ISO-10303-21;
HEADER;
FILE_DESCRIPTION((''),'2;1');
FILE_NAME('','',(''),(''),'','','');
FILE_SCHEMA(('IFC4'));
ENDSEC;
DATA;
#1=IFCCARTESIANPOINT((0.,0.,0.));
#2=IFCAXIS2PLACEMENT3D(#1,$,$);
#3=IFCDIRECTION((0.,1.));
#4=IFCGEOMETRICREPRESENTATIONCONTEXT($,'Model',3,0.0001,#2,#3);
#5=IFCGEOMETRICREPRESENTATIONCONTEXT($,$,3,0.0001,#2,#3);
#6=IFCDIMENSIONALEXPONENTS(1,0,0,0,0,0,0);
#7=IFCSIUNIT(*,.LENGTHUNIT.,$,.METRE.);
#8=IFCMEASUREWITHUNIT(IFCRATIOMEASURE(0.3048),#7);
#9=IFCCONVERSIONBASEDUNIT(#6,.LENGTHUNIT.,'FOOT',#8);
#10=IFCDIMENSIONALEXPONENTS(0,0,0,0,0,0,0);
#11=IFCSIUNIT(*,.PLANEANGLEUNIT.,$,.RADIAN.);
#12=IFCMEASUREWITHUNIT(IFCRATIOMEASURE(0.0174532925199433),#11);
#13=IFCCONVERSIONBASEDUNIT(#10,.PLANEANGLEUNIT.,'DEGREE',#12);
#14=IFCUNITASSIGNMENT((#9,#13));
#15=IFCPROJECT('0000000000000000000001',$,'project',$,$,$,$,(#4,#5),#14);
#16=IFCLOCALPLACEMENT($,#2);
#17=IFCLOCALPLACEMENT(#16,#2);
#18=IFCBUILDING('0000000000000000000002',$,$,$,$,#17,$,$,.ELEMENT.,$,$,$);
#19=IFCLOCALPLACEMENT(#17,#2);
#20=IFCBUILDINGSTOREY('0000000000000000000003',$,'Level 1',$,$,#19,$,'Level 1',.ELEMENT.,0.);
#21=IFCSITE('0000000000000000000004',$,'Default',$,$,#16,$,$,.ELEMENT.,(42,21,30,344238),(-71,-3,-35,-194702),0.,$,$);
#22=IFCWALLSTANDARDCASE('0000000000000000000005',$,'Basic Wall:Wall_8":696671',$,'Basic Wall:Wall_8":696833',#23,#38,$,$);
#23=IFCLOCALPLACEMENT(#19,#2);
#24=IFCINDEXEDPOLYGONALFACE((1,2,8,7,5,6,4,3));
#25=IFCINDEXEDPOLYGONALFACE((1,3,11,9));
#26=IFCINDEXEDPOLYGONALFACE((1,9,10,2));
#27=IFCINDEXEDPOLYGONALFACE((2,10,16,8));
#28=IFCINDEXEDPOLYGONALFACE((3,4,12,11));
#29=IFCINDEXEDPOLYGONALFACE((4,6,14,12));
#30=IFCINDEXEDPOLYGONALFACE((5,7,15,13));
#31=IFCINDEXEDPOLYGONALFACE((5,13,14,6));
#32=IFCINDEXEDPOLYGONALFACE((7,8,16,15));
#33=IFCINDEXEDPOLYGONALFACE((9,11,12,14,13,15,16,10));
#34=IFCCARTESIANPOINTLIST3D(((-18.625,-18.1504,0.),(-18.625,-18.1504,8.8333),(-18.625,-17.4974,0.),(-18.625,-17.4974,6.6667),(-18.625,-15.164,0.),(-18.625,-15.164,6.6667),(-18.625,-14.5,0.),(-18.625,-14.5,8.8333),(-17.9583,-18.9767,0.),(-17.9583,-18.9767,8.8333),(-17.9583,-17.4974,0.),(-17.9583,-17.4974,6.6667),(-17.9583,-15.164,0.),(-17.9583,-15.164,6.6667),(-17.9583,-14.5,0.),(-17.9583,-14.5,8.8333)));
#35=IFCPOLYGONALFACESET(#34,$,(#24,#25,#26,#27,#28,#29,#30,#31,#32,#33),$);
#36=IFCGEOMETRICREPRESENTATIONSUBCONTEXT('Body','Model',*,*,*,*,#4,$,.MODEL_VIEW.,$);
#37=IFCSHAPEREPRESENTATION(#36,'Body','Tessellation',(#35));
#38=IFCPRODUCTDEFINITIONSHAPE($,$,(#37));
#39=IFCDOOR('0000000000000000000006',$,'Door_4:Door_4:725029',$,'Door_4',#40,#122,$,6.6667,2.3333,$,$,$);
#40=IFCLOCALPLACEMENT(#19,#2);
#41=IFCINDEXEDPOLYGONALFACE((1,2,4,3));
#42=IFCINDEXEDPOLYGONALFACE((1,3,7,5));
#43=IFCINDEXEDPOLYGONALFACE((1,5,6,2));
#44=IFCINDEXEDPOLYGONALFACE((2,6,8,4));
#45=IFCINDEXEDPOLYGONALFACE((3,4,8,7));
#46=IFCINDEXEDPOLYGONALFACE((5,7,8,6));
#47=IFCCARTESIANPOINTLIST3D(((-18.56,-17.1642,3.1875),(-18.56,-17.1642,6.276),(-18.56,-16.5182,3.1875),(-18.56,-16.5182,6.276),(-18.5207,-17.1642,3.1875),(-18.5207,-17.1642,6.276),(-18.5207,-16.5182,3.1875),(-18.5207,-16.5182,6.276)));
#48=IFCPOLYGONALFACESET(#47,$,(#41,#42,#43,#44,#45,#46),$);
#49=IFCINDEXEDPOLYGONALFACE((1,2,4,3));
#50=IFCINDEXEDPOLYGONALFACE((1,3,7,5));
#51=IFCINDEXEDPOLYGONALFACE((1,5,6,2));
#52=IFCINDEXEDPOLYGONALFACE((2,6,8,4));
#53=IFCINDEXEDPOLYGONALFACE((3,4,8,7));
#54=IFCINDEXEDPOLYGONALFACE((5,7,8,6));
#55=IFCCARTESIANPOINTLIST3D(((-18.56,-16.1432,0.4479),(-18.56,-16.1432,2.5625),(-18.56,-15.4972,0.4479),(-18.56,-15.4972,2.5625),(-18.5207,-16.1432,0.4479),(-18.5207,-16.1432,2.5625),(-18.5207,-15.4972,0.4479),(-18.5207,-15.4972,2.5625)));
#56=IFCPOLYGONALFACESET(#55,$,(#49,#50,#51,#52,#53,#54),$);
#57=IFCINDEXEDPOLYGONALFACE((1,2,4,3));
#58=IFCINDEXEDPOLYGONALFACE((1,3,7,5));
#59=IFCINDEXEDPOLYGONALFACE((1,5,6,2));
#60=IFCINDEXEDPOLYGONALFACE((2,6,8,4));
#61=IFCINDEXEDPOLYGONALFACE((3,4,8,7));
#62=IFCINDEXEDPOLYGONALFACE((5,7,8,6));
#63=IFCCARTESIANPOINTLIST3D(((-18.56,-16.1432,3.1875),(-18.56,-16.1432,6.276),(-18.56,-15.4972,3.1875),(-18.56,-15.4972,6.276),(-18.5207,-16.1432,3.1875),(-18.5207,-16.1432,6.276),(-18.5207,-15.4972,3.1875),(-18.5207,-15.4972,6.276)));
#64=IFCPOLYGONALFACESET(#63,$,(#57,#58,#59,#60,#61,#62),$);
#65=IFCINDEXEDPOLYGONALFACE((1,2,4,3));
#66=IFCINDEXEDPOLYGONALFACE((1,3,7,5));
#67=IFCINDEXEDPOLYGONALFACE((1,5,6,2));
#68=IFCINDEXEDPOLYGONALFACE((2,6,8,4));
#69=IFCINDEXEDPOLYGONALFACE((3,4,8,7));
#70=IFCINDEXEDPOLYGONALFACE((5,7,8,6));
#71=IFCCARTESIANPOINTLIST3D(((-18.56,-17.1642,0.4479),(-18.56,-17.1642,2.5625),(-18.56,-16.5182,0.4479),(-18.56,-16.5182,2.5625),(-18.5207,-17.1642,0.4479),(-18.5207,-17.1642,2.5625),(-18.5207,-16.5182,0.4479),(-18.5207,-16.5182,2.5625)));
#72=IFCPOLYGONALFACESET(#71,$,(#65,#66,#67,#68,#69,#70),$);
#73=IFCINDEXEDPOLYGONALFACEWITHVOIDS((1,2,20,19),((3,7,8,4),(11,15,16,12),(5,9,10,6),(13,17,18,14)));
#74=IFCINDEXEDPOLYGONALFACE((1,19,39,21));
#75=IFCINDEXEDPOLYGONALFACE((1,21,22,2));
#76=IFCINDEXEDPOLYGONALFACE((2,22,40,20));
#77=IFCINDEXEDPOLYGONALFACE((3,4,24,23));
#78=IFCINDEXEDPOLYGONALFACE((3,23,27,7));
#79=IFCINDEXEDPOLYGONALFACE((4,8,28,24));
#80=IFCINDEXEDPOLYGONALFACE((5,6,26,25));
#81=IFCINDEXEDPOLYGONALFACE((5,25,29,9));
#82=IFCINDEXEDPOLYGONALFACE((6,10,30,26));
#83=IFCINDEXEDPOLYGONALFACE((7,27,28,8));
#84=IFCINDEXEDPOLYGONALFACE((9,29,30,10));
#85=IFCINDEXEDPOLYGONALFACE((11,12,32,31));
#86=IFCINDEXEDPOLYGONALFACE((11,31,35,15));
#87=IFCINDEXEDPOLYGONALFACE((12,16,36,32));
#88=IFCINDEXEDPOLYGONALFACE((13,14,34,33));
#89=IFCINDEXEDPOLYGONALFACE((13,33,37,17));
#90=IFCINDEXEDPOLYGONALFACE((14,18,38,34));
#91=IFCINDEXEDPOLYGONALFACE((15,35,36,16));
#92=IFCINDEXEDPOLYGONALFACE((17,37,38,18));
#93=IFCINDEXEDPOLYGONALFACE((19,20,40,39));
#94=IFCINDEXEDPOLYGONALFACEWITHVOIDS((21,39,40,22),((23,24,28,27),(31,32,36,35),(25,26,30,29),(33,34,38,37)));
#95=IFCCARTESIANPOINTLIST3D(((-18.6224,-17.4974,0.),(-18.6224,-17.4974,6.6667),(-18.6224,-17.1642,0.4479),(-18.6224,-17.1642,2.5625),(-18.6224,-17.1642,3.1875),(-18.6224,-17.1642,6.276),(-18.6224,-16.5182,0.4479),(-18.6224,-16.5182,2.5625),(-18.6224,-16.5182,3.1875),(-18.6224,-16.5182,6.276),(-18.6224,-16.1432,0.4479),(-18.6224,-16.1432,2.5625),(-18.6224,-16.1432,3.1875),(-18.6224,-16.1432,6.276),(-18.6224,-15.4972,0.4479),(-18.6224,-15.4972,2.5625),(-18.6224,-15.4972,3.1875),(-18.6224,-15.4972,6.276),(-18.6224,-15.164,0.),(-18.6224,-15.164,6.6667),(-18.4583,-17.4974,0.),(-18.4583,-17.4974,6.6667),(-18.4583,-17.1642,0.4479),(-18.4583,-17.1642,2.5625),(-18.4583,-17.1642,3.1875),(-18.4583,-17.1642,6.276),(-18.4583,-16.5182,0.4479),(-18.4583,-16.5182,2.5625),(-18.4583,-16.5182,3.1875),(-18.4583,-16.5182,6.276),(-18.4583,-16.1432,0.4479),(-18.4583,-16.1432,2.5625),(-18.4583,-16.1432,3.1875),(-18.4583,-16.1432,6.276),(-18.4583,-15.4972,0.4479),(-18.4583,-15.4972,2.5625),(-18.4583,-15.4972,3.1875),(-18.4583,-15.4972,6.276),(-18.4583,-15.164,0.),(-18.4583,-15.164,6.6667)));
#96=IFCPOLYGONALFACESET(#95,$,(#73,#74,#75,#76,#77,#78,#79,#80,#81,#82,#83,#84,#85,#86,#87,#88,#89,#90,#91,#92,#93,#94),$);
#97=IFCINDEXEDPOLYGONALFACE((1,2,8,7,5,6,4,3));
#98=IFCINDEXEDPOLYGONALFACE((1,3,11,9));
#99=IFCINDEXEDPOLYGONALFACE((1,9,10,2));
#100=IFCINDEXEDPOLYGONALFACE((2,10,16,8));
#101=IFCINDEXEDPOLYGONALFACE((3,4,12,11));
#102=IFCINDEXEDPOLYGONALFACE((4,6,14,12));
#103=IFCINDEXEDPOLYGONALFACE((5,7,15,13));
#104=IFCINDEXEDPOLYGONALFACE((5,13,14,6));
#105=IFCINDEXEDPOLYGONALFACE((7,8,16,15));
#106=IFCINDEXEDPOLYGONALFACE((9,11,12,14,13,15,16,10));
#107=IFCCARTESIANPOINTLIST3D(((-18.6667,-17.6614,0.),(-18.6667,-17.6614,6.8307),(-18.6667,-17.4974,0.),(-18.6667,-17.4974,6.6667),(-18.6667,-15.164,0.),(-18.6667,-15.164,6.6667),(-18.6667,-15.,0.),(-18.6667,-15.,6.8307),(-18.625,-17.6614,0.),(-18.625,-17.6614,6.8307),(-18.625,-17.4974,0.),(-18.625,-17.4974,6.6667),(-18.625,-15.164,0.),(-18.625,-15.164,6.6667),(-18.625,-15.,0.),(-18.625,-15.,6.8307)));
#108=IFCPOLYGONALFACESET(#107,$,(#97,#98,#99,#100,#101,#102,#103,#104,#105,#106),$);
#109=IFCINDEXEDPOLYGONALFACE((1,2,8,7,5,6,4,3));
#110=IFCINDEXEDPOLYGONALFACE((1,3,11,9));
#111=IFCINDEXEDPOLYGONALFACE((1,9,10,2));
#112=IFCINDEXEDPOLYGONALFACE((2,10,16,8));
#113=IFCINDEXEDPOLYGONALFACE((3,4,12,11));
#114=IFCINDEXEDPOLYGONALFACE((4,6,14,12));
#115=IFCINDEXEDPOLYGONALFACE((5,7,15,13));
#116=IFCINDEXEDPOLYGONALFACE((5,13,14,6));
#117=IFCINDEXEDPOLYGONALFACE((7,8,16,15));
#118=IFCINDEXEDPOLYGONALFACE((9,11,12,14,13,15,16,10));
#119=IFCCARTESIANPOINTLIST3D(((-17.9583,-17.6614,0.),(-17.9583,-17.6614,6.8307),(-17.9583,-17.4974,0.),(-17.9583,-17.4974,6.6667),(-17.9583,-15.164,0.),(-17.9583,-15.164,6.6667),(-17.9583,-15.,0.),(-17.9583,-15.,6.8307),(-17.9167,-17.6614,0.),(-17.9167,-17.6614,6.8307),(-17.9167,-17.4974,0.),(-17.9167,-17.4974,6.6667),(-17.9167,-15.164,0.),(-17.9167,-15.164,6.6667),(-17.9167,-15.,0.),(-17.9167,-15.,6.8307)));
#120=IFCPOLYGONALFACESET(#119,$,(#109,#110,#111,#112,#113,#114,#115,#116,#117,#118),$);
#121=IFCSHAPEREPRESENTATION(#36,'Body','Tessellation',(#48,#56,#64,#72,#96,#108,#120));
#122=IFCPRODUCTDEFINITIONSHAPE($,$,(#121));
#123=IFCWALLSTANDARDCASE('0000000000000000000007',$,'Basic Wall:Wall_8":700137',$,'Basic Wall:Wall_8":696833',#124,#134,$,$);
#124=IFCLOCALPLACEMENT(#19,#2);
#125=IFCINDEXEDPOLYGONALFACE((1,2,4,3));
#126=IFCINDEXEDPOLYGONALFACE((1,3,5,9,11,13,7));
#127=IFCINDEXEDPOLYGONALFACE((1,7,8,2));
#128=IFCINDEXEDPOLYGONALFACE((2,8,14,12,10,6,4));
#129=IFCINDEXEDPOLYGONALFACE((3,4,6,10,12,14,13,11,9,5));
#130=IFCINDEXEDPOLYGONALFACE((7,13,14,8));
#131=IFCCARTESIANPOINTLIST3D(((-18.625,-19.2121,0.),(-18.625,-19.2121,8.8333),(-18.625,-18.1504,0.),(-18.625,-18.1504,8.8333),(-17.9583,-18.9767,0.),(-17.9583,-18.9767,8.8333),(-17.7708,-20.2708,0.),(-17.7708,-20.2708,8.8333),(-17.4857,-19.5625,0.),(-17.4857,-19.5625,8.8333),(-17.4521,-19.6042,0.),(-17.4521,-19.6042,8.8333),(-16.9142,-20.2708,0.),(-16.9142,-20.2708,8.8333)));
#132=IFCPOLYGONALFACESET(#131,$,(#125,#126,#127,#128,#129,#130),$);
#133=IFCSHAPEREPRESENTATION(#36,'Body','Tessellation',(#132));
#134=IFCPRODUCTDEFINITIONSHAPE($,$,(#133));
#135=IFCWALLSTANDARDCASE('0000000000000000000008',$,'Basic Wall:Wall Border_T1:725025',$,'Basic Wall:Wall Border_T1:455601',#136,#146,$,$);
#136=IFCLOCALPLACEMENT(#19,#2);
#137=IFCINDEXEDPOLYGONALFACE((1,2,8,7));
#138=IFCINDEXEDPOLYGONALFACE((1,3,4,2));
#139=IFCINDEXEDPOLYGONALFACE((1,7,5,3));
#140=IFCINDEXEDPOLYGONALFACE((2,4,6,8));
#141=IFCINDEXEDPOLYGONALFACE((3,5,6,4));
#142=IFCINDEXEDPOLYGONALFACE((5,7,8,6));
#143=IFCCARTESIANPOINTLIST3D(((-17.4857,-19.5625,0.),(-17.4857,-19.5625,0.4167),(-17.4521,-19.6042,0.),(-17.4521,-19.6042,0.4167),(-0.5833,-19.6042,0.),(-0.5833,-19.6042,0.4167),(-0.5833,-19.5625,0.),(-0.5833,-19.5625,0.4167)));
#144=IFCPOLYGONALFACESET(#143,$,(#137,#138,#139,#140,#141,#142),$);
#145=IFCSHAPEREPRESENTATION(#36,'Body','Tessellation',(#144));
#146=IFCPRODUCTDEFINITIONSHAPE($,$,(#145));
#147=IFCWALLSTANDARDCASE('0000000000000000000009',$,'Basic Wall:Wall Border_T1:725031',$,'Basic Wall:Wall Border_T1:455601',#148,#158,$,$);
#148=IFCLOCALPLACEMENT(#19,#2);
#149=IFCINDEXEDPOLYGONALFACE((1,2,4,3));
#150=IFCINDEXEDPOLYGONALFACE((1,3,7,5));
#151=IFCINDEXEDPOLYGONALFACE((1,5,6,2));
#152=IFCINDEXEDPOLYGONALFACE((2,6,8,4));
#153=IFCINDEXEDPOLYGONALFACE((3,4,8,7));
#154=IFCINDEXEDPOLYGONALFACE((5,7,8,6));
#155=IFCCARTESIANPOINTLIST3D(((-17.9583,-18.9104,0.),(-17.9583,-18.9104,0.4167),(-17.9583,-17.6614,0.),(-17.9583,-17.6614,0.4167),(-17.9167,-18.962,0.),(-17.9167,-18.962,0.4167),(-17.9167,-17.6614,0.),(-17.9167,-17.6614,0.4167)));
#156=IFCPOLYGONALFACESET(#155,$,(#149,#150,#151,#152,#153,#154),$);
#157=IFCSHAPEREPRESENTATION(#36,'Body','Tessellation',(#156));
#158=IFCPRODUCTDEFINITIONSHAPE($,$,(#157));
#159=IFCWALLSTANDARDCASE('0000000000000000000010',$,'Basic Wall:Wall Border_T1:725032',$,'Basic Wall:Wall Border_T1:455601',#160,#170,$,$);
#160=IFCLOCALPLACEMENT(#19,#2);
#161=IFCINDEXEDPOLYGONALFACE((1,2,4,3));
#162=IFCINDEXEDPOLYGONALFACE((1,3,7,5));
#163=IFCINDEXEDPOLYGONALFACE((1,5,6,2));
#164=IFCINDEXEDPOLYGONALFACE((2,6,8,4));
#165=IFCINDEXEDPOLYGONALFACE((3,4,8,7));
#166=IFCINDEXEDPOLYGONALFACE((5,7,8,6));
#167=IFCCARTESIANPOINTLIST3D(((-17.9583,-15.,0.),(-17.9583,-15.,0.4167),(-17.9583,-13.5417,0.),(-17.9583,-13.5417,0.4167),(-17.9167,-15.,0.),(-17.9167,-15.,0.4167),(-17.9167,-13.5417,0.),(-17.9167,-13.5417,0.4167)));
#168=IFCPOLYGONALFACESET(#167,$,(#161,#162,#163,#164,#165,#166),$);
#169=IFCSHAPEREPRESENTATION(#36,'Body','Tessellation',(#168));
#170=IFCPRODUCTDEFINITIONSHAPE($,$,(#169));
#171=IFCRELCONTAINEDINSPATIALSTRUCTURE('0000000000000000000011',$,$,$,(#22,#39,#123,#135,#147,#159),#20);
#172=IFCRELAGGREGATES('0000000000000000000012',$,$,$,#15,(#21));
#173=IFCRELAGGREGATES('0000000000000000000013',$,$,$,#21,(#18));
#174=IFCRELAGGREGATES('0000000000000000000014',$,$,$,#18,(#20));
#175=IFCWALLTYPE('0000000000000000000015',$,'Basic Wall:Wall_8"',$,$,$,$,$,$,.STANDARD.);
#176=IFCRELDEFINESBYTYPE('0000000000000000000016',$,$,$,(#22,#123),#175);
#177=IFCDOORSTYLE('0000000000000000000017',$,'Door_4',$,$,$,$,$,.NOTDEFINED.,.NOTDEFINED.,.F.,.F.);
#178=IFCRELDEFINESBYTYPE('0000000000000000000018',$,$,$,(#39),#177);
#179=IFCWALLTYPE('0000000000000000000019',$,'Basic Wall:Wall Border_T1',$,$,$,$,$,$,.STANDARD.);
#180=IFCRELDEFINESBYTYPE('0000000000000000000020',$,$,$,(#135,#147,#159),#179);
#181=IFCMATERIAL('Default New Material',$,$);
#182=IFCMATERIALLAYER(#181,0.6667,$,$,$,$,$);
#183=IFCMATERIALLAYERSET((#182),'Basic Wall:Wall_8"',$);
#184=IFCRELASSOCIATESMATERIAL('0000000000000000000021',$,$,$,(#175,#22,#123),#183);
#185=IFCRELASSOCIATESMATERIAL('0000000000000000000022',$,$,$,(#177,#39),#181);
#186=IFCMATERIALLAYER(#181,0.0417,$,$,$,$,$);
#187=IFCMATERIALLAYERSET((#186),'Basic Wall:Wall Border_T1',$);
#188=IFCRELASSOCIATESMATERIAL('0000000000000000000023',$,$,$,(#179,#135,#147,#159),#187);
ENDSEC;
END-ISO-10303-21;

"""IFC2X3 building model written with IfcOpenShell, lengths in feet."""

from ifc_helpers import new_model, entity, si_unit, converted_unit, direction, frame, frame_2d, origin, place, context, subcontext, project, spatial, polyline, rectangle, outline, extrude, clip, bounded_halfspace, source, transform, mapped, material, layer, layer_set, layer_usage, type_object, type_shapes, element, fill, save


model = new_model("IFC2X3")

# Units and contexts
model_context = context("Model", 3, precision=0.0001, world=origin(), true_north=direction((0.0, 1.0)))
context_of_model = context(None, 3, precision=0.0001, world=origin(), true_north=direction((0.0, 1.0)))
body_context = subcontext(model_context, "Body", "Model", "MODEL_VIEW")
ifc_project = project(units=[converted_unit("LENGTHUNIT", "FOOT", entity("IfcRatioMeasure", 0.3048), si_unit("LENGTHUNIT", "METRE"), dimensions=[1, 0, 0, 0, 0, 0, 0]), converted_unit("PLANEANGLEUNIT", "DEGREE", entity("IfcRatioMeasure", 0.0174532925199433), si_unit("PLANEANGLEUNIT", "RADIAN"), dimensions=[0, 0, 0, 0, 0, 0, 0])], contexts=[model_context, context_of_model])

# Site, building, storey
site_placement = place(None, origin())
site = spatial("IfcSite", under=ifc_project, at=site_placement, Name="Default", CompositionType="ELEMENT", RefLatitude=(42, 21, 30, 344238), RefLongitude=(-71, -3, -35, -194702), RefElevation=0.0)
building_placement = place(site_placement, origin())
building = spatial("IfcBuilding", under=site, at=building_placement, CompositionType="ELEMENT")
storey_placement = place(building_placement, origin())
storey = spatial("IfcBuildingStorey", under=building, at=storey_placement, Name="Level 1", LongName="Level 1", CompositionType="ELEMENT", Elevation=0.0)

# Shared definitions
ifc_material = material(Name="Default New Material")
ifc_layer_1 = layer(ifc_material, 0.6667)
ifc_layer_set_1 = layer_set([ifc_layer_1], Name="Basic Wall:Wall_8\"")
wall_type_1 = type_object("IfcWallType", Name="Basic Wall:Wall_8\"", PredefinedType="STANDARD", material=ifc_layer_set_1)

# Wall, opening, door
ifc_layer_usage_1 = layer_usage(ifc_layer_set_1, "AXIS2", "NEGATIVE", 0.3333)
wall_1_placement = place(storey_placement, frame((-18.2917, -18.9767, 0.0), z_axis=(0.0, 0.0, 1.0), x_axis=(0.0, 1.0, 0.0)))
wall_1 = element("IfcWallStandardCase", 1, at=wall_1_placement, inside=storey, type_object=wall_type_1, material=ifc_layer_usage_1, Name="Basic Wall:Wall_8\":696671", ObjectType="Basic Wall:Wall_8\":696833", context=body_context, shape_type="SweptSolid", body=[
    extrude(outline(polyline([(0.0, -0.3333), (4.4767, -0.3333), (4.4767, 0.0417), (4.4767, 0.3333), (0.8263, 0.3333), (0.0, -0.3333)])), origin(), (0.0, 0.0, 1.0), 8.8333),
])
opening_1_placement = place(wall_1_placement, frame((3.8127, 0.3333, 0.0)))
opening_1 = element("IfcOpeningElement", 2, at=opening_1_placement, cuts=wall_1, ObjectType="Opening", context=body_context, shape_type="SweptSolid", body=[
    extrude(rectangle(XDim=6.6667, YDim=2.3333, at=frame_2d((3.3333, 1.1667), x_axis=(1.0, 0.0))), frame((0.0, 0.0, 0.0), z_axis=(0.0, -1.0, 0.0), x_axis=(0.0, 0.0, 1.0)), (0.0, 0.0, 1.0), 0.6667),
])
door_style = type_object("IfcDoorStyle", Name="Door_4", ConstructionType="NOTDEFINED", OperationType="NOTDEFINED", ParameterTakesPrecedence=False, Sizeable=False, material=ifc_material)
shared_shape_1 = source(origin(), body_context, "Body", "SweptSolid", [
    extrude(rectangle(XDim=0.0394, YDim=0.646, at=frame_2d((0.0, 0.0), x_axis=(1.0, 0.0))), frame((1.6772, 0.0846, 3.1875), z_axis=(0.0, 0.0, 1.0), x_axis=(0.0, 1.0, 0.0)), (0.0, 0.0, 1.0), 3.0885),
    extrude(rectangle(XDim=0.0394, YDim=0.646, at=frame_2d((0.0, 0.0), x_axis=(1.0, 0.0))), frame((0.6562, 0.0846, 0.4479), z_axis=(0.0, 0.0, 1.0), x_axis=(0.0, 1.0, 0.0)), (0.0, 0.0, 1.0), 2.1146),
    extrude(rectangle(XDim=0.0394, YDim=0.646, at=frame_2d((0.0, 0.0), x_axis=(1.0, 0.0))), frame((0.6562, 0.0846, 3.1875), z_axis=(0.0, 0.0, 1.0), x_axis=(0.0, 1.0, 0.0)), (0.0, 0.0, 1.0), 3.0885),
    extrude(rectangle(XDim=0.0394, YDim=0.646, at=frame_2d((0.0, 0.0), x_axis=(1.0, 0.0))), frame((1.6772, 0.0846, 0.4479), z_axis=(0.0, 0.0, 1.0), x_axis=(0.0, 1.0, 0.0)), (0.0, 0.0, 1.0), 2.1146),
    extrude(outline(polyline([(-1.1667, -3.3333), (1.1667, -3.3333), (1.1667, 3.3333), (-1.1667, 3.3333), (-1.1667, -3.3333)]), holes=[polyline([(0.8335, -2.9427), (0.1875, -2.9427), (0.1875, 0.1458), (0.8335, 0.1458), (0.8335, -2.9427)]), polyline([(-0.1875, 0.1458), (-0.1875, -2.9427), (-0.8335, -2.9427), (-0.8335, 0.1458), (-0.1875, 0.1458)]), polyline([(0.1875, 0.7708), (0.1875, 2.8854), (0.8335, 2.8854), (0.8335, 0.7708), (0.1875, 0.7708)]), polyline([(-0.1875, 2.8854), (-0.1875, 0.7708), (-0.8335, 0.7708), (-0.8335, 2.8854), (-0.1875, 2.8854)])]), frame((1.1667, 0.0026, 3.3333), z_axis=(0.0, 1.0, 0.0), x_axis=(1.0, 0.0, 0.0)), (0.0, 0.0, 1.0), 0.164),
    extrude(outline(polyline([(-3.2923, 1.1667), (3.3743, 1.1667), (3.3743, 1.3307), (-3.4564, 1.3307), (-3.4564, -1.3307), (3.3743, -1.3307), (3.3743, -1.1667), (-3.2923, -1.1667), (-3.2923, 1.1667)])), frame((1.1667, -0.0417, 3.3743), z_axis=(0.0, 1.0, 0.0), x_axis=(0.0, 0.0, -1.0)), (0.0, 0.0, 1.0), 0.0417),
    extrude(outline(polyline([(-3.2923, 1.1667), (3.3743, 1.1667), (3.3743, 1.3307), (-3.4564, 1.3307), (-3.4564, -1.3307), (3.3743, -1.3307), (3.3743, -1.1667), (-3.2923, -1.1667), (-3.2923, 1.1667)])), frame((1.1667, 0.6667, 3.3743), z_axis=(0.0, 1.0, 0.0), x_axis=(0.0, 0.0, -1.0)), (0.0, 0.0, 1.0), 0.0417),
])
type_shapes(door_style, [shared_shape_1])
door_placement = place(opening_1_placement, frame((0.0, 0.0, 0.0), z_axis=(0.0, 0.0, 1.0), x_axis=(-1.0, 0.0, 0.0)))
door = element("IfcDoor", 3, at=door_placement, inside=storey, type_object=door_style, material=ifc_material, Name="Door_4:Door_4:725029", ObjectType="Door_4", OverallHeight=6.6667, OverallWidth=2.3333, context=body_context, shape_type="MappedRepresentation", body=[
    mapped(shared_shape_1, transform((0.0, 0.0, 0.0), scale=1.0)),
])
fill(opening_1, door)

# Walls
ifc_layer_usage_2 = layer_usage(ifc_layer_set_1, "AXIS2", "NEGATIVE", 0.3333)
wall_2_placement = place(storey_placement, frame((-18.8844, -18.3597, 0.0), z_axis=(0.0, 0.0, 1.0), x_axis=(0.627919, -0.778278, 0.0)))
element("IfcWallStandardCase", 4, at=wall_2_placement, inside=storey, type_object=wall_type_1, material=ifc_layer_usage_2, Name="Basic Wall:Wall_8\":700137", ObjectType="Basic Wall:Wall_8\":696833", context=body_context, shape_type="SweptSolid", body=[
    extrude(outline(polyline([(2.1866, -0.3333), (2.7245, 0.3333), (1.8679, 0.3333), (1.8144, 0.3333), (1.0617, 0.3333), (0.0, 0.3333), (0.8263, -0.3333), (2.1866, -0.3333)])), origin(), (0.0, 0.0, 1.0), 8.8333),
])
ifc_layer_2 = layer(ifc_material, 0.0417)
ifc_layer_set_2 = layer_set([ifc_layer_2], Name="Basic Wall:Wall Border_T1")
ifc_layer_usage_3 = layer_usage(ifc_layer_set_2, "AXIS2", "POSITIVE", -0.0208)
wall_type_2 = type_object("IfcWallType", Name="Basic Wall:Wall Border_T1", PredefinedType="STANDARD", material=ifc_layer_set_2)
wall_3_placement = place(storey_placement, frame((-0.5833, -19.5833, 0.0), z_axis=(0.0, 0.0, 1.0), x_axis=(-1.0, 0.0, 0.0)))
element("IfcWallStandardCase", 5, at=wall_3_placement, inside=storey, type_object=wall_type_2, material=ifc_layer_usage_3, Name="Basic Wall:Wall Border_T1:725025", ObjectType="Basic Wall:Wall Border_T1:455601", context=body_context, shape_type="Clipping", body=[
    clip(extrude(outline(polyline([(16.8688, 0.0208), (0.0, 0.0208), (0.0, -0.0208), (16.8489, -0.0208), (16.9024, -0.0208), (16.8688, 0.0208)])), origin(), (0.0, 0.0, 1.0), 0.4167), bounded_halfspace(frame((0.0, -0.0208, 0.0), z_axis=(1.0, 0.0, 0.0), x_axis=(0.0, 1.0, 0.0)), True, frame((0.0, -0.0208, 0.0), z_axis=(1.0, 0.0, 0.0), x_axis=(0.0, 1.0, 0.0)), polyline([(0.0, 0.0), (0.0417, 0.0), (0.0417, 0.4167), (0.0, 0.4167), (0.0, 0.0)]))),
])
ifc_layer_usage_4 = layer_usage(ifc_layer_set_2, "AXIS2", "POSITIVE", -0.0208)
wall_4_placement = place(storey_placement, frame((-17.9375, -18.962, 0.0), z_axis=(0.0, 0.0, 1.0), x_axis=(0.0, 1.0, 0.0)))
element("IfcWallStandardCase", 6, at=wall_4_placement, inside=storey, type_object=wall_type_2, material=ifc_layer_usage_4, Name="Basic Wall:Wall Border_T1:725031", ObjectType="Basic Wall:Wall Border_T1:455601", context=body_context, shape_type="Clipping", body=[
    clip(extrude(rectangle(XDim=1.3006, YDim=0.0417, at=frame_2d((0.6503, 0.0), x_axis=(-1.0, 0.0))), origin(), (0.0, 0.0, 1.0), 0.4167), bounded_halfspace(frame((0.0, -0.0208, 0.0), z_axis=(0.627919, -0.778278, 0.0), x_axis=(0.778278, 0.627919, 0.0)), True, frame((0.0, -0.0208, 0.0), z_axis=(0.627919, -0.778278, 0.0), x_axis=(0.778278, 0.627919, 0.0)), polyline([(0.0, 0.0), (0.0664, 0.0), (0.0664, 0.4167), (0.0, 0.4167), (0.0, 0.0)]))),
])
ifc_layer_usage_5 = layer_usage(ifc_layer_set_2, "AXIS2", "POSITIVE", -0.0208)
wall_5_placement = place(storey_placement, frame((-17.9375, -15.0, 0.0), z_axis=(0.0, 0.0, 1.0), x_axis=(0.0, 1.0, 0.0)))
element("IfcWallStandardCase", 7, at=wall_5_placement, inside=storey, type_object=wall_type_2, material=ifc_layer_usage_5, Name="Basic Wall:Wall Border_T1:725032", ObjectType="Basic Wall:Wall Border_T1:455601", context=body_context, shape_type="SweptSolid", body=[
    extrude(rectangle(XDim=1.4583, YDim=0.0417, at=frame_2d((0.7292, 0.0), x_axis=(-1.0, 0.0))), origin(), (0.0, 0.0, 1.0), 0.4167),
])

save(model, "model.ifc")
